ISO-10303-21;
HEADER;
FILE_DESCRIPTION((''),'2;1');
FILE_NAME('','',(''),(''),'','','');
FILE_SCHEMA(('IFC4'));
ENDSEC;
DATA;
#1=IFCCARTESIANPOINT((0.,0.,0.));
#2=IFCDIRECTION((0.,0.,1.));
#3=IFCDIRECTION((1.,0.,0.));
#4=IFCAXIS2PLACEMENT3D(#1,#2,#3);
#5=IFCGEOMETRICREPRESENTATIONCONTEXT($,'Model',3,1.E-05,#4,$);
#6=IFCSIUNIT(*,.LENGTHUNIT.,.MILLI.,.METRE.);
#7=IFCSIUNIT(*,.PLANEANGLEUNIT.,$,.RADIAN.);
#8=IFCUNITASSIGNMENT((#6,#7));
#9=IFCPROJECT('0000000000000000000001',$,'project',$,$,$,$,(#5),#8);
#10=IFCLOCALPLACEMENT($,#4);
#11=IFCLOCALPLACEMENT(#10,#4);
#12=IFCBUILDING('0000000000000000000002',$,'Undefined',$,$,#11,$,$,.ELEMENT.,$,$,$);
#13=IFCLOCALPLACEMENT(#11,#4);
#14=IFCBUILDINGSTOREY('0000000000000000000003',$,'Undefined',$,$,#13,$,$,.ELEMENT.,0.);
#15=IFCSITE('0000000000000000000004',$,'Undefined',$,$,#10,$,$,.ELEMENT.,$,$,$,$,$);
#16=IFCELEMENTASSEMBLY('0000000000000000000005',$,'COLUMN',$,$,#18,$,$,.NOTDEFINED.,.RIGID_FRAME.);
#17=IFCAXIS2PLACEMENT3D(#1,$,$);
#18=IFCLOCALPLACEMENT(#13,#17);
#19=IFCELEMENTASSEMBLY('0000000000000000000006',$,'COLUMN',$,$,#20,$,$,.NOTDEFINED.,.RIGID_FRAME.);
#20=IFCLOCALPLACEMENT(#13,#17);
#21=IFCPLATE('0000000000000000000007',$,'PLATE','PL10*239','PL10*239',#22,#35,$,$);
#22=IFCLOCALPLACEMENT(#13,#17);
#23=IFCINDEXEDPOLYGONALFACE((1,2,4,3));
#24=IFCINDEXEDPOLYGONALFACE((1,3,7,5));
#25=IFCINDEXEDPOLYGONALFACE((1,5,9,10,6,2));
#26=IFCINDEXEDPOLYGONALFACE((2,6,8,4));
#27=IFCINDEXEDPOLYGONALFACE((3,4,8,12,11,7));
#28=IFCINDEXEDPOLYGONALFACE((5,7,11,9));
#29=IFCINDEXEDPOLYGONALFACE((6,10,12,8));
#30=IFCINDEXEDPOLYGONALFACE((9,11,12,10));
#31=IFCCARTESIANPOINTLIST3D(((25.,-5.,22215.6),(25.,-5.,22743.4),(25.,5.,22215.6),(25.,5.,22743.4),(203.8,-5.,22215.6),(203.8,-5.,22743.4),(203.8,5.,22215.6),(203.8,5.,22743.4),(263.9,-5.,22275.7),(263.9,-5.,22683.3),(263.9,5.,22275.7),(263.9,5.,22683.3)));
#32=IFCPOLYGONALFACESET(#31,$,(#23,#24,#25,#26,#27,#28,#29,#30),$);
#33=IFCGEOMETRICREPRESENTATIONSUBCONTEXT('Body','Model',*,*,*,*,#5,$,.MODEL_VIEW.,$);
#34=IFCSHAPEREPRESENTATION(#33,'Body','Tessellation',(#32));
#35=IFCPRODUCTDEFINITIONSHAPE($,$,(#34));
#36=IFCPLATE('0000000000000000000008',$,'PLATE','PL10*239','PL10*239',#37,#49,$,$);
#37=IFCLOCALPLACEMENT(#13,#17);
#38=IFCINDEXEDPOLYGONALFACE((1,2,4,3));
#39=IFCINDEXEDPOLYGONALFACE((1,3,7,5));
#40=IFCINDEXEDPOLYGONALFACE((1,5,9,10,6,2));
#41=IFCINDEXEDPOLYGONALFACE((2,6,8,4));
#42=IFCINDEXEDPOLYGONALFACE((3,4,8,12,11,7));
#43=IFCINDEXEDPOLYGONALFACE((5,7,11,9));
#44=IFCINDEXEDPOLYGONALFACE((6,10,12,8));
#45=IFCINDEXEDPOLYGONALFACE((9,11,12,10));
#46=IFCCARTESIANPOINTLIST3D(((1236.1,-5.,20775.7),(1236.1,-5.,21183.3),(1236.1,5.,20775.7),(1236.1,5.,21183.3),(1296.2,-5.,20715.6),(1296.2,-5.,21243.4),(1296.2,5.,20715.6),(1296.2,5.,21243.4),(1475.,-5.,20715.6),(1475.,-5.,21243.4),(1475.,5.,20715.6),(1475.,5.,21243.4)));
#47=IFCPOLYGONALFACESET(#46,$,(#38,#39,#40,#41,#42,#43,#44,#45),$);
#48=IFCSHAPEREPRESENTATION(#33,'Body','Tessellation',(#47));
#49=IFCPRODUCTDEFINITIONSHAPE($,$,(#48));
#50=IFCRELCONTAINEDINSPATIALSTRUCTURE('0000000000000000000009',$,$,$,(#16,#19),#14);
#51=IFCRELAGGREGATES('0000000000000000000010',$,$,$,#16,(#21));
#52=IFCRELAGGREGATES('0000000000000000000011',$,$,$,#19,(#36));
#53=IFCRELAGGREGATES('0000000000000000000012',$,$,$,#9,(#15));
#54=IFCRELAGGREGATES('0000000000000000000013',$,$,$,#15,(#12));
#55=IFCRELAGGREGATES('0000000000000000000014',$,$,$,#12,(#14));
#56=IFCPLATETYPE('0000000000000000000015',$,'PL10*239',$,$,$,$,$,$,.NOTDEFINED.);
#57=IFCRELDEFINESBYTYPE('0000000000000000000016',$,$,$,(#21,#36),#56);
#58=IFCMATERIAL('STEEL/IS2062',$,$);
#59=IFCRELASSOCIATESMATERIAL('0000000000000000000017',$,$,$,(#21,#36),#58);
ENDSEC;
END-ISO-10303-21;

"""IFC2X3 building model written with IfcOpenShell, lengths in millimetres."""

from ifc_helpers import new_model, si_unit, frame, origin_with_axes, place, context, subcontext, project, spatial, polyline, outline, extrude, material, type_object, element, aggregate, save


model = new_model("IFC2X3")

# Units and contexts
model_context = context("Model", 3, precision=1e-05, world=origin_with_axes())
body_context = subcontext(model_context, "Body", "Model", "MODEL_VIEW")
ifc_project = project(units=[si_unit("LENGTHUNIT", "METRE", prefix="MILLI"), si_unit("PLANEANGLEUNIT", "RADIAN")], contexts=[model_context])

# Site, building, storey
site_placement = place(None, origin_with_axes())
site = spatial("IfcSite", under=ifc_project, at=site_placement, Name="Undefined", CompositionType="ELEMENT")
building_placement = place(site_placement, origin_with_axes())
building = spatial("IfcBuilding", under=site, at=building_placement, Name="Undefined", CompositionType="ELEMENT")
storey_placement = place(building_placement, origin_with_axes())
storey = spatial("IfcBuildingStorey", under=building, at=storey_placement, Name="Undefined", CompositionType="ELEMENT", Elevation=0.0)

# Shared definitions
ifc_material = material(Name="STEEL/IS2062")

# Element assemblies
assembly_1_placement = place(storey_placement, origin_with_axes())
assembly_1 = element("IfcElementAssembly", 1, at=assembly_1_placement, inside=storey, Name="COLUMN", AssemblyPlace="NOTDEFINED", PredefinedType="RIGID_FRAME")
assembly_2_placement = place(storey_placement, origin_with_axes())
assembly_2 = element("IfcElementAssembly", 2, at=assembly_2_placement, inside=storey, Name="COLUMN", AssemblyPlace="NOTDEFINED", PredefinedType="RIGID_FRAME")

# Plates
plate_type_1 = type_object("IfcPlateType", Name="PL10*239", PredefinedType="NOTDEFINED")
plate_1_placement = place(assembly_1_placement, frame((25.0, 0.0, 22215.6), z_axis=(0.0, 1.0, 0.0), x_axis=(0.0, 0.0, 1.0)))
plate_1 = element("IfcPlate", 3, at=plate_1_placement, type_object=plate_type_1, material=ifc_material, Name="PLATE", Description="PL10*239", ObjectType="PL10*239", context=body_context, shape_type="SweptSolid", body=[
    extrude(outline(polyline([(0.0, 0.0), (527.8, 0.0), (527.8, 178.8), (467.7, 238.9), (60.1, 238.9), (0.0, 178.8), (0.0, 0.0)])), frame((0.0, 0.0, -5.0), z_axis=(0.0, 0.0, 1.0), x_axis=(1.0, 0.0, 0.0)), (0.0, 0.0, 1.0), 10.0),
])
aggregate(assembly_1, [plate_1])
plate_2_placement = place(assembly_2_placement, frame((1475.0, 0.0, 21243.4), z_axis=(0.0, 1.0, 0.0), x_axis=(0.0, 0.0, -1.0)))
plate_2 = element("IfcPlate", 4, at=plate_2_placement, type_object=plate_type_1, material=ifc_material, Name="PLATE", Description="PL10*239", ObjectType="PL10*239", context=body_context, shape_type="SweptSolid", body=[
    extrude(outline(polyline([(0.0, 0.0), (527.8, 0.0), (527.8, 178.8), (467.7, 238.9), (60.1, 238.9), (0.0, 178.8), (0.0, 0.0)])), frame((0.0, 0.0, -5.0), z_axis=(0.0, 0.0, 1.0), x_axis=(1.0, 0.0, 0.0)), (0.0, 0.0, 1.0), 10.0),
])
aggregate(assembly_2, [plate_2])

save(model, "model.ifc")
